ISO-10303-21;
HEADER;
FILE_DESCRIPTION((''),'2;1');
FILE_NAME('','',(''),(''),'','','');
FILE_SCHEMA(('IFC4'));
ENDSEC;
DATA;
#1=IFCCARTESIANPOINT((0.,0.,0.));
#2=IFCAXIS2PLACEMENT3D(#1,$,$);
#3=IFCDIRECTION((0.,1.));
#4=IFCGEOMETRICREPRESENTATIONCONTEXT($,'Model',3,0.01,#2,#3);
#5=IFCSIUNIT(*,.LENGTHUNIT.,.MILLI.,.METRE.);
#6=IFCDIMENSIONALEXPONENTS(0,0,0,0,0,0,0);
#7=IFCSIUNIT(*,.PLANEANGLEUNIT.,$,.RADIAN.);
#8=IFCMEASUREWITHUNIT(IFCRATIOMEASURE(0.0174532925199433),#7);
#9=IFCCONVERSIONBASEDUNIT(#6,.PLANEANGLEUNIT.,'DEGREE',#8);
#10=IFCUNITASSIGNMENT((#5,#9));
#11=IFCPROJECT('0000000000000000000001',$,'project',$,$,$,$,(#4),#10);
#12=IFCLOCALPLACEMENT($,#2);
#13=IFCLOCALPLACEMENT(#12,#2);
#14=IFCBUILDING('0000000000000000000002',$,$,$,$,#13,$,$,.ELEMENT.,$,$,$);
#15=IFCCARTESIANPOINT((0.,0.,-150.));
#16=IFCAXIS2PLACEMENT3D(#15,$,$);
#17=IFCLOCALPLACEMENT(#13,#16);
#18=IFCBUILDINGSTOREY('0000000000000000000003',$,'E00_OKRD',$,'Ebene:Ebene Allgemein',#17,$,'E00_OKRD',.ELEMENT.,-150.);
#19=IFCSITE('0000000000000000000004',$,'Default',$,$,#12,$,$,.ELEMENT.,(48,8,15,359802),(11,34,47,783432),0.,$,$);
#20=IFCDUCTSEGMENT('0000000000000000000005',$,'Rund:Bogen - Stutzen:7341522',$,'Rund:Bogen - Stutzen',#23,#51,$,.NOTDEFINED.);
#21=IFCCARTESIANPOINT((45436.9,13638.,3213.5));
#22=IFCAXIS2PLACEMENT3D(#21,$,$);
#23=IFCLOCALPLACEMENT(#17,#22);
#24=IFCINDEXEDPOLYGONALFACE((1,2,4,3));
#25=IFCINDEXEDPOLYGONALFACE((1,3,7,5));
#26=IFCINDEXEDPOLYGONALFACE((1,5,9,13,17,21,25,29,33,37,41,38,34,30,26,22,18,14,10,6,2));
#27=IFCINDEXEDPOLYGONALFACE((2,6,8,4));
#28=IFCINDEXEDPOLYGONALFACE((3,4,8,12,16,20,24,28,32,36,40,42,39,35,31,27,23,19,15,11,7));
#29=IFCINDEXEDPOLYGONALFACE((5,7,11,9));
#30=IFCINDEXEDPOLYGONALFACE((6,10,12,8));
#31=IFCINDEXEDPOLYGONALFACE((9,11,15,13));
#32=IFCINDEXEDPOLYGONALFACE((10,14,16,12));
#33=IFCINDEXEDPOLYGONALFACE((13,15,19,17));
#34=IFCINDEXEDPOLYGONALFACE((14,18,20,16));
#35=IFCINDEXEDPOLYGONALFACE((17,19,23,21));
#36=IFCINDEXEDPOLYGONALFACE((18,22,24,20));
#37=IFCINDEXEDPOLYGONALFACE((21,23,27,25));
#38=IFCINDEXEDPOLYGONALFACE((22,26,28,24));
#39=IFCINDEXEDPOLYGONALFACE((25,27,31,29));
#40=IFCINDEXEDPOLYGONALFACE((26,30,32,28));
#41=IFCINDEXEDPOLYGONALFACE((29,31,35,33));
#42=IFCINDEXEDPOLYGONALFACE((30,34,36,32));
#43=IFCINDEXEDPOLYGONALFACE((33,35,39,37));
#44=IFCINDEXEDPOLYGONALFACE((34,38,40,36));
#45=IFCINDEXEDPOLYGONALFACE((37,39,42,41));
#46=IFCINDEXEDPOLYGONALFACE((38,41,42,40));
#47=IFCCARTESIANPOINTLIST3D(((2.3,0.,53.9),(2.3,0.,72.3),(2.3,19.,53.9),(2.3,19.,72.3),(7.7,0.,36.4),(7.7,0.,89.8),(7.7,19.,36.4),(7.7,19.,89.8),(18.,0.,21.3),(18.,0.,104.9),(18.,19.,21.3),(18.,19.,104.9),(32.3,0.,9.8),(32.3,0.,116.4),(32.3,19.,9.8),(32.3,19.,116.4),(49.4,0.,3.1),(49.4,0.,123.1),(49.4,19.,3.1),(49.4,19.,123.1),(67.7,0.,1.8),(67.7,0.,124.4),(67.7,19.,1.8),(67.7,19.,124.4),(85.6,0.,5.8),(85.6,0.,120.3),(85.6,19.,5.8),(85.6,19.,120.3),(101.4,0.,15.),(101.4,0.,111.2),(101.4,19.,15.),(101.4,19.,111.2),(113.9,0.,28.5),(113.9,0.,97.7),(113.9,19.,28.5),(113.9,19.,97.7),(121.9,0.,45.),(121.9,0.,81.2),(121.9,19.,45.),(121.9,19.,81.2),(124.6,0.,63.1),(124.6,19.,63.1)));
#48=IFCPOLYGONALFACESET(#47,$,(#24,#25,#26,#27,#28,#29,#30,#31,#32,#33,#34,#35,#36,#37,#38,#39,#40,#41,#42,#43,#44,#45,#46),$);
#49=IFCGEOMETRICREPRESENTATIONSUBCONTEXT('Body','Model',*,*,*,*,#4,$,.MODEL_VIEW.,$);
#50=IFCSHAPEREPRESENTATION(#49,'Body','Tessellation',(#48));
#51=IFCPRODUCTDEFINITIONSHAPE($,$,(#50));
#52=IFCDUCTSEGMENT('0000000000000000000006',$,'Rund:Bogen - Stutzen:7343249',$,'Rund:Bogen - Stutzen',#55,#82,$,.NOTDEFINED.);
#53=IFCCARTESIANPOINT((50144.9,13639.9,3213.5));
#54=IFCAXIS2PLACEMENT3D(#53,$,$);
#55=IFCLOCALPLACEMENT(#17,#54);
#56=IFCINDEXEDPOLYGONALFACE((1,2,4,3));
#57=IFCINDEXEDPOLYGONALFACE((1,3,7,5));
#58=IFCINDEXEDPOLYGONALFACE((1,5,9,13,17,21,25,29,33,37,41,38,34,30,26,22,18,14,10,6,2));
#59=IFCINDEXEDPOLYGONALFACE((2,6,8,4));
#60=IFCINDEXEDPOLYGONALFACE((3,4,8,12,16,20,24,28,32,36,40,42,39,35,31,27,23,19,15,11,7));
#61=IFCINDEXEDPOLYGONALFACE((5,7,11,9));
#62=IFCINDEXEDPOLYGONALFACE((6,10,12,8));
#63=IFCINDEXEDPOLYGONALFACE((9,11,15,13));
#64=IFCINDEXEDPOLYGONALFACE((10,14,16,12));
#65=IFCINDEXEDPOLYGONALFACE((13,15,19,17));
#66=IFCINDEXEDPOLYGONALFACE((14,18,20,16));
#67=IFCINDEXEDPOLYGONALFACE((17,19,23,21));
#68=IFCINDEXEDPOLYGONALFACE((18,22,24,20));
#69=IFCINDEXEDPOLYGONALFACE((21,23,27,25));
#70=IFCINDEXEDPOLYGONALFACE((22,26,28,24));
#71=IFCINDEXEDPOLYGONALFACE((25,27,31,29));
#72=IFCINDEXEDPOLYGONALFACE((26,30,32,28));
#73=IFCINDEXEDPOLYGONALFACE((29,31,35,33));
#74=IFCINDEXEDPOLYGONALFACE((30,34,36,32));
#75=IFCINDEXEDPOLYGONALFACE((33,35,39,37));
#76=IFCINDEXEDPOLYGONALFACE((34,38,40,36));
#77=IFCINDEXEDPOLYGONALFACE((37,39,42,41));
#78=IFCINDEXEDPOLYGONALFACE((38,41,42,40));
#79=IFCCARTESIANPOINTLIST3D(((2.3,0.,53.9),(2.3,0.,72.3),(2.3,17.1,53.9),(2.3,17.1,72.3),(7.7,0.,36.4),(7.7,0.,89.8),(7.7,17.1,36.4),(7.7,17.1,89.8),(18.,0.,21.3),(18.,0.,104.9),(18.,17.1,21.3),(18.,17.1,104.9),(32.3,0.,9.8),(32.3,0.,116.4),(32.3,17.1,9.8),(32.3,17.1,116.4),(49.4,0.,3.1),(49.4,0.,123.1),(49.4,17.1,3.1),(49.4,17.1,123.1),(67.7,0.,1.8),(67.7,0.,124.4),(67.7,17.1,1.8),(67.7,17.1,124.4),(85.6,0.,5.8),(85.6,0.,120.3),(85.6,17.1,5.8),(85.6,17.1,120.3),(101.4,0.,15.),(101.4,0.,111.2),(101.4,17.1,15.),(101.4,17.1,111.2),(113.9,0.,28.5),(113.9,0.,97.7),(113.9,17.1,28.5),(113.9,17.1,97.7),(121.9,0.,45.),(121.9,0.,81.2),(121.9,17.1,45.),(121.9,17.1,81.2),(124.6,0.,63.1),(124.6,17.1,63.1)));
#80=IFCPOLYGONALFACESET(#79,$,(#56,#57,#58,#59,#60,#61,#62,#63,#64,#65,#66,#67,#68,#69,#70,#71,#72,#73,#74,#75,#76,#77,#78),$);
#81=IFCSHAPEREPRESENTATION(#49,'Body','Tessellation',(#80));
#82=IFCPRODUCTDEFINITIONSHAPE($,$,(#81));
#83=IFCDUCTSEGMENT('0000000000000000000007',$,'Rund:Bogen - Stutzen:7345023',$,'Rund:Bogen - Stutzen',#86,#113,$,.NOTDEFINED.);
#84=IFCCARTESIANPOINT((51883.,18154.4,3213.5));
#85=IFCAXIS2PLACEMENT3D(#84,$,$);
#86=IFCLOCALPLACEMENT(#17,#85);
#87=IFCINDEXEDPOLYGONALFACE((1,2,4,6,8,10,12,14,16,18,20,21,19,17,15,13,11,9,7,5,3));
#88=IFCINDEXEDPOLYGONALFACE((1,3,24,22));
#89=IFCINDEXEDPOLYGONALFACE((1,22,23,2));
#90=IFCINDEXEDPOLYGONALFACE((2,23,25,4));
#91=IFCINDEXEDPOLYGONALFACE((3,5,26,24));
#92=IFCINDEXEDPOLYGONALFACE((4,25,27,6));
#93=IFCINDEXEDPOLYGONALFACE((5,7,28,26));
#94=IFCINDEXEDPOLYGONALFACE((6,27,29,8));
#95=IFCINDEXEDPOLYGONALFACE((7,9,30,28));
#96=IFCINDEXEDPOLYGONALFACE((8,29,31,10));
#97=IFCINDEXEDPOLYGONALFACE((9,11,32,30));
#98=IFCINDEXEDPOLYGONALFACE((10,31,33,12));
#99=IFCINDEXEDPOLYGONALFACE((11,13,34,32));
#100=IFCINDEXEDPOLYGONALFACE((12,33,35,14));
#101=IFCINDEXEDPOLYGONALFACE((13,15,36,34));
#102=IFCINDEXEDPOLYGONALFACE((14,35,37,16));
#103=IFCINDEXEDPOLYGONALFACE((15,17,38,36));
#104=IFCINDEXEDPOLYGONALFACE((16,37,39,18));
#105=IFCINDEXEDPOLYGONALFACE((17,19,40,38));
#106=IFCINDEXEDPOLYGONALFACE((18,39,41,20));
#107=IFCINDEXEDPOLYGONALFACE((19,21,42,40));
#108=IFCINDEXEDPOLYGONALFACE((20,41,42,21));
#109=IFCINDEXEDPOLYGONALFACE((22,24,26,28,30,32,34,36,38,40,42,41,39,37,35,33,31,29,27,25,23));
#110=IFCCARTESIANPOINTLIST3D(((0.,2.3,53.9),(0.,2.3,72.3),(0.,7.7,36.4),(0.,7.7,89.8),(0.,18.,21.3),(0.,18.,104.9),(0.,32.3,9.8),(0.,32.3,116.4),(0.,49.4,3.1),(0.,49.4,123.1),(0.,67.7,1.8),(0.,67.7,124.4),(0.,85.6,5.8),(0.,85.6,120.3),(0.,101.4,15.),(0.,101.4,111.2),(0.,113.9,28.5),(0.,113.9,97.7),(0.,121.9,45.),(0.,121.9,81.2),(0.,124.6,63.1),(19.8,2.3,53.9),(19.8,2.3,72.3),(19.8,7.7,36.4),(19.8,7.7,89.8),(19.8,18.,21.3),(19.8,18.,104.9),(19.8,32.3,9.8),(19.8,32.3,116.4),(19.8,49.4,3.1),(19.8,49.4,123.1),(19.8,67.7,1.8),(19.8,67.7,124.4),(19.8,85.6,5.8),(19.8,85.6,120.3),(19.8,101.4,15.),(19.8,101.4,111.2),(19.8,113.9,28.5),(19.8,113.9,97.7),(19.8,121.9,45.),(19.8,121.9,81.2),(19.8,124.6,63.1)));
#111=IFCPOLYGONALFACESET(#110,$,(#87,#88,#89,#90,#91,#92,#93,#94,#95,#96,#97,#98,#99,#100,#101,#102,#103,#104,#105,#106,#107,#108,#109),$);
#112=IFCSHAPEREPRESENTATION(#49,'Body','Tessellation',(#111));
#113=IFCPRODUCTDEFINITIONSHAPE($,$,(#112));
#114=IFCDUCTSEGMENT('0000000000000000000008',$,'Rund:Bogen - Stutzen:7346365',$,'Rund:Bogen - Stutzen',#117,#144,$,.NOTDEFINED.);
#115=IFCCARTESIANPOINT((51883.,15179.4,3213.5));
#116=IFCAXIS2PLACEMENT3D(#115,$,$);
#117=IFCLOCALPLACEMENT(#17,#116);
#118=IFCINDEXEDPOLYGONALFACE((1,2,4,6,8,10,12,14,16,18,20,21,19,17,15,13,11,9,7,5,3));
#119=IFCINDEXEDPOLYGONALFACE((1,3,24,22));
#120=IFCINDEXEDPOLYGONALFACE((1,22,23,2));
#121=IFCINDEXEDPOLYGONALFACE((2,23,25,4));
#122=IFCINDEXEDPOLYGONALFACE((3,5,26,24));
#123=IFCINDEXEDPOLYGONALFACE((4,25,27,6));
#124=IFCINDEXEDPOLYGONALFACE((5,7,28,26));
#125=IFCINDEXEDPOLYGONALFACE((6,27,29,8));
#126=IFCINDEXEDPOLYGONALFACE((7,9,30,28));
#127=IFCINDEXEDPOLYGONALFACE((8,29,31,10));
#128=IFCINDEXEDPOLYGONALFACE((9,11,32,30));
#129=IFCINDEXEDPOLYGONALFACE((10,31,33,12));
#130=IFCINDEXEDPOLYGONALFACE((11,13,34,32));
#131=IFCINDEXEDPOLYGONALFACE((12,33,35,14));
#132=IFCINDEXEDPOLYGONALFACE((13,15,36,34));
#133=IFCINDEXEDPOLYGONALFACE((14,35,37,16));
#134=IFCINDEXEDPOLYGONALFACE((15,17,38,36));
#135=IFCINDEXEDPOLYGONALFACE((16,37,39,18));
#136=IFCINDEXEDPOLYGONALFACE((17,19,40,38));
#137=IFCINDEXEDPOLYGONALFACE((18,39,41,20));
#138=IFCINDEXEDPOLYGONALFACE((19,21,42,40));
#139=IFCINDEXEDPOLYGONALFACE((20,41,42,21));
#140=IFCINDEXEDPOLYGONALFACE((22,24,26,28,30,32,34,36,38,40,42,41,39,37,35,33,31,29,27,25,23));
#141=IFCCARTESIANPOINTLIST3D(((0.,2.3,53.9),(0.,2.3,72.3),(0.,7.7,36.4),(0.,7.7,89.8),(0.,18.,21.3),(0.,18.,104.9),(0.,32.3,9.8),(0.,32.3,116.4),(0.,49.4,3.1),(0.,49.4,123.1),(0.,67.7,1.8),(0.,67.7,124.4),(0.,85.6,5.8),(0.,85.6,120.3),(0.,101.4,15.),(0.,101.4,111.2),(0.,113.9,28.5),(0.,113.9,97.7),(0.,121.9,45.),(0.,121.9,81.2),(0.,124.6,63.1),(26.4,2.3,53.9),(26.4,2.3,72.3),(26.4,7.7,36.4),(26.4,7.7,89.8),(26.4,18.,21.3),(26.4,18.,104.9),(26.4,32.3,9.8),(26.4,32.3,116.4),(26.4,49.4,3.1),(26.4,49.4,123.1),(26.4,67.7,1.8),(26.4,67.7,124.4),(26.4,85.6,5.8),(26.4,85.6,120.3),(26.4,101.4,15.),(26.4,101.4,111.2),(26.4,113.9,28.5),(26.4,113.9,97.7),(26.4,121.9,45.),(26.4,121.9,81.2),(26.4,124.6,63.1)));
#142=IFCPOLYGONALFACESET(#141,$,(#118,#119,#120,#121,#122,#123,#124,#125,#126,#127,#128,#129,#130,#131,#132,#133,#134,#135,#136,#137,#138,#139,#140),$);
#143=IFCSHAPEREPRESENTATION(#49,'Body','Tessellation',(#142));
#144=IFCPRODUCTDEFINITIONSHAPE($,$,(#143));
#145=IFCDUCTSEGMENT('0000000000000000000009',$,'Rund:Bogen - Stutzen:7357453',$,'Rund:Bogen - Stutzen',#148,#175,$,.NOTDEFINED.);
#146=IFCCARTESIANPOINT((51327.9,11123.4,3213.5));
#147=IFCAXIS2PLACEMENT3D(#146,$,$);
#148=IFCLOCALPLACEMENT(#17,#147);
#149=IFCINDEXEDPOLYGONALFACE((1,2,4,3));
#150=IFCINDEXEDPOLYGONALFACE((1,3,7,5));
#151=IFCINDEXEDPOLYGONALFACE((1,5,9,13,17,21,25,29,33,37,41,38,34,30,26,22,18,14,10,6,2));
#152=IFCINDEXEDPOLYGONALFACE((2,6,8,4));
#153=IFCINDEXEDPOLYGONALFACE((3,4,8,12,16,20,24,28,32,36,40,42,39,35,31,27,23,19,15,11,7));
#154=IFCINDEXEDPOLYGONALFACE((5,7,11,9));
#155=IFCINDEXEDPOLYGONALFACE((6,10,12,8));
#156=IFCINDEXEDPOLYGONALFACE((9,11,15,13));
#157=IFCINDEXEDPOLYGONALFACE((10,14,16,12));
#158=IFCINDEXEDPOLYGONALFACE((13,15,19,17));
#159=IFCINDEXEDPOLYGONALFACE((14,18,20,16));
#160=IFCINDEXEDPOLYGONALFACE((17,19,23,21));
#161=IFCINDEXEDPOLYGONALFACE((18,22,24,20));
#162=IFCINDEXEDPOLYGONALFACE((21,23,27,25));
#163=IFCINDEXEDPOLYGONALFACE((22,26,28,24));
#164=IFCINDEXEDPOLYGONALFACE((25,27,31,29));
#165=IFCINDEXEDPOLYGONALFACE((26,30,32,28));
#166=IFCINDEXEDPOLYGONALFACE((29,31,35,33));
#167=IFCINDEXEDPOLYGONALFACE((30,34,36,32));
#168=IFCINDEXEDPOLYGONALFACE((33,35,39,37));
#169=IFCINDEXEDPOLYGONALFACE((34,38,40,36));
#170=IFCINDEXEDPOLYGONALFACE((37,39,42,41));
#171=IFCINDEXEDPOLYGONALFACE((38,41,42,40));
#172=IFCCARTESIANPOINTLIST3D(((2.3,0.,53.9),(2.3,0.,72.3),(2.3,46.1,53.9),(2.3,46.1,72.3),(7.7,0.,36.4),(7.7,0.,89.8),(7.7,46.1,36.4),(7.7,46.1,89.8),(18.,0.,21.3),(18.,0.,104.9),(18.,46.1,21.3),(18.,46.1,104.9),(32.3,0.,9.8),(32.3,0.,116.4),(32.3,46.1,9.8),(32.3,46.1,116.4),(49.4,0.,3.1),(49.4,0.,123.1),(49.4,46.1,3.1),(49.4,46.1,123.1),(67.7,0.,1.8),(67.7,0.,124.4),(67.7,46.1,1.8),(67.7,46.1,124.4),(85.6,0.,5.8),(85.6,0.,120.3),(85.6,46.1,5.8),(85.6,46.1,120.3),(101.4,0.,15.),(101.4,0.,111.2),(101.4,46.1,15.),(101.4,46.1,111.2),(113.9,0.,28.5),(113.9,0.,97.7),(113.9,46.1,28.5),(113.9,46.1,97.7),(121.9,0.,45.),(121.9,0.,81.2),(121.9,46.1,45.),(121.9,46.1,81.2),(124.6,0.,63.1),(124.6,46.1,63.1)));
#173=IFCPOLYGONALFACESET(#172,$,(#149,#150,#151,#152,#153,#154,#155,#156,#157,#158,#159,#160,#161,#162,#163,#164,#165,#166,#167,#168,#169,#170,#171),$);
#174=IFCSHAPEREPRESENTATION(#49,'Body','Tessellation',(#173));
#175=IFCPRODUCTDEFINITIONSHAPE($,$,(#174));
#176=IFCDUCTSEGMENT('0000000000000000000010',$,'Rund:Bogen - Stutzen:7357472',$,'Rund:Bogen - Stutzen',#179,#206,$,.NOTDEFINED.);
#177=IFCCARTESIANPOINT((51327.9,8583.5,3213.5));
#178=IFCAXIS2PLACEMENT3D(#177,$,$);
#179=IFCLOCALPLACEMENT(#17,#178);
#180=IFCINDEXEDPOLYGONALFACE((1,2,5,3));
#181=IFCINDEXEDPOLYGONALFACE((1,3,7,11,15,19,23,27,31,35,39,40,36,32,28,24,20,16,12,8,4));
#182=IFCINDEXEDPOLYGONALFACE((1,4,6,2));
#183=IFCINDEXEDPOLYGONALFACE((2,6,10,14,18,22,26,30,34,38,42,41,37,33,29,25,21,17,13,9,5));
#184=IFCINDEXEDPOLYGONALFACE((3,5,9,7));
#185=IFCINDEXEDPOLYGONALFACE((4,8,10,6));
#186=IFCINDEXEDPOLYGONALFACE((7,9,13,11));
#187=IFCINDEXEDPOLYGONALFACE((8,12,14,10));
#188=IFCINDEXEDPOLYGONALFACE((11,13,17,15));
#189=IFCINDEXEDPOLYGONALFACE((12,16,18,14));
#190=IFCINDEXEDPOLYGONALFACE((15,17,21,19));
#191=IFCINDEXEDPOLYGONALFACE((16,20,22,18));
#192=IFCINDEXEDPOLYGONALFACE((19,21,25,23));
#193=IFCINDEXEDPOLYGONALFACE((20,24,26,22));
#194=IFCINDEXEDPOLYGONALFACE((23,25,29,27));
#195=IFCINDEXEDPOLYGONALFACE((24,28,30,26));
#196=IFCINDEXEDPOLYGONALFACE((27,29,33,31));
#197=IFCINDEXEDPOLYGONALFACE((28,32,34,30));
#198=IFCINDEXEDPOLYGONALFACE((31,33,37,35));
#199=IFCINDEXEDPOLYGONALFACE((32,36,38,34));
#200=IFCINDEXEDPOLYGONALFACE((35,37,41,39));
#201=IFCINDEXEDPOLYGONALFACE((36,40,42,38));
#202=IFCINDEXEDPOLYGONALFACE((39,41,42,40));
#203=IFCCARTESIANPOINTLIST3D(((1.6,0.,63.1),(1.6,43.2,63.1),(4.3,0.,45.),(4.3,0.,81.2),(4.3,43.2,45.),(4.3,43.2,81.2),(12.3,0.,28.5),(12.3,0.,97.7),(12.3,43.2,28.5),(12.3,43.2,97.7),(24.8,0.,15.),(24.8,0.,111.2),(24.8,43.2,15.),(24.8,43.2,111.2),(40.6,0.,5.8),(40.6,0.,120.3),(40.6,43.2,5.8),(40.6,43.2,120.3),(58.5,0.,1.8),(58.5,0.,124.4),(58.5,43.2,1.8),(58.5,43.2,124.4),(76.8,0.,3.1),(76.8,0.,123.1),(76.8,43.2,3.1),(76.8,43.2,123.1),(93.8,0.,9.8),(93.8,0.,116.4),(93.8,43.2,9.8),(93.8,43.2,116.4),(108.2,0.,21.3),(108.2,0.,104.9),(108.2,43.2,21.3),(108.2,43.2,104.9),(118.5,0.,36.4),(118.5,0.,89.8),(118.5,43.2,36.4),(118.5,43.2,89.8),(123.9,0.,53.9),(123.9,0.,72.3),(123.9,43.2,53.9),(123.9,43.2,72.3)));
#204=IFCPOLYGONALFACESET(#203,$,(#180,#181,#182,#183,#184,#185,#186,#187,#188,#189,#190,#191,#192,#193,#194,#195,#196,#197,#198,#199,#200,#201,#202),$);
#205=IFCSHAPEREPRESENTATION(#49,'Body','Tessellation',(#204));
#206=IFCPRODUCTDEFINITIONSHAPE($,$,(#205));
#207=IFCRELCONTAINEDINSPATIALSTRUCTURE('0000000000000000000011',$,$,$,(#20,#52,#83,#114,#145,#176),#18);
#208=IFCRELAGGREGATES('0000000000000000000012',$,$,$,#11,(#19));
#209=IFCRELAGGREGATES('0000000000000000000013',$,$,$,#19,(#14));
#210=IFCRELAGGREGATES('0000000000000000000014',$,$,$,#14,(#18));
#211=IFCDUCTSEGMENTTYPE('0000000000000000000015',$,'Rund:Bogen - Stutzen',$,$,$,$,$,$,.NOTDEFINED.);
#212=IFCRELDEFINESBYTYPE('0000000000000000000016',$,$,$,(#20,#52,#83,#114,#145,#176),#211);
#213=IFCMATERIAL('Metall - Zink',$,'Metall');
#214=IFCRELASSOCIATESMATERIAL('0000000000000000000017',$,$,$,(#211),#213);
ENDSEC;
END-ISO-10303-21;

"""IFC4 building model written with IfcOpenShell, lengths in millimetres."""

from ifc_helpers import new_model, entity, si_unit, converted_unit, direction, frame, frame_2d, origin, origin_2d_with_axis, place, context, subcontext, project, spatial, circle, extrude, material, type_object, element, save


model = new_model("IFC4")

# Units and contexts
model_context = context("Model", 3, precision=0.01, world=origin(), true_north=direction((0.0, 1.0)))
body_context = subcontext(model_context, "Body", "Model", "MODEL_VIEW")
ifc_project = project(units=[si_unit("LENGTHUNIT", "METRE", prefix="MILLI"), converted_unit("PLANEANGLEUNIT", "DEGREE", entity("IfcRatioMeasure", 0.0174532925199433), si_unit("PLANEANGLEUNIT", "RADIAN"), dimensions=[0, 0, 0, 0, 0, 0, 0])], contexts=[model_context])

# Site, building, storey
site_placement = place(None, origin())
site = spatial("IfcSite", under=ifc_project, at=site_placement, Name="Default", CompositionType="ELEMENT", RefLatitude=(48, 8, 15, 359802), RefLongitude=(11, 34, 47, 783432), RefElevation=0.0)
building_placement = place(site_placement, origin())
building = spatial("IfcBuilding", under=site, at=building_placement, CompositionType="ELEMENT")
storey_placement = place(building_placement, frame((0.0, 0.0, -150.0)))
storey = spatial("IfcBuildingStorey", under=building, at=storey_placement, Name="E00_OKRD", ObjectType="Ebene:Ebene Allgemein", LongName="E00_OKRD", CompositionType="ELEMENT", Elevation=-150.0)

# Shared definitions
ifc_material_1 = material(Name="Metall - Zink", Category="Metall")

# Duct segments
duct_segment_type_1 = type_object("IfcDuctSegmentType", Name="Rund:Bogen - Stutzen", PredefinedType="NOTDEFINED", material=ifc_material_1)
duct_segment_1_placement = place(storey_placement, frame((45436.9, 13638.0, 3213.5)))
element("IfcDuctSegment", 1, at=duct_segment_1_placement, inside=storey, type_object=duct_segment_type_1, Name="Rund:Bogen - Stutzen:7341522", ObjectType="Rund:Bogen - Stutzen", PredefinedType="NOTDEFINED", context=body_context, shape_type="SweptSolid", body=[
    extrude(circle(Radius=61.5, at=frame_2d((0.0, 0.0), x_axis=(1.0, 0.0))), frame((63.1, 0.0, 63.1), z_axis=(0.0, 1.0, 0.0), x_axis=(1.0, 0.0, 0.0)), (0.0, 0.0, 1.0), 19.0),
])
duct_segment_2_placement = place(storey_placement, frame((50144.9, 13639.9, 3213.5)))
element("IfcDuctSegment", 2, at=duct_segment_2_placement, inside=storey, type_object=duct_segment_type_1, Name="Rund:Bogen - Stutzen:7343249", ObjectType="Rund:Bogen - Stutzen", PredefinedType="NOTDEFINED", context=body_context, shape_type="SweptSolid", body=[
    extrude(circle(Radius=61.5, at=frame_2d((0.0, 0.0), x_axis=(1.0, 0.0))), frame((63.1, 0.0, 63.1), z_axis=(0.0, 1.0, 0.0), x_axis=(1.0, 0.0, 0.0)), (0.0, 0.0, 1.0), 17.1),
])
duct_segment_3_placement = place(storey_placement, frame((51883.0, 18154.4, 3213.5)))
element("IfcDuctSegment", 3, at=duct_segment_3_placement, inside=storey, type_object=duct_segment_type_1, Name="Rund:Bogen - Stutzen:7345023", ObjectType="Rund:Bogen - Stutzen", PredefinedType="NOTDEFINED", context=body_context, shape_type="SweptSolid", body=[
    extrude(circle(Radius=61.5, at=origin_2d_with_axis()), frame((0.0, 63.1, 63.1), z_axis=(1.0, 0.0, 0.0), x_axis=(0.0, 1.0, 0.0)), (0.0, 0.0, 1.0), 19.8),
])
duct_segment_4_placement = place(storey_placement, frame((51883.0, 15179.4, 3213.5)))
element("IfcDuctSegment", 4, at=duct_segment_4_placement, inside=storey, type_object=duct_segment_type_1, Name="Rund:Bogen - Stutzen:7346365", ObjectType="Rund:Bogen - Stutzen", PredefinedType="NOTDEFINED", context=body_context, shape_type="SweptSolid", body=[
    extrude(circle(Radius=61.5, at=origin_2d_with_axis()), frame((0.0, 63.1, 63.1), z_axis=(1.0, 0.0, 0.0), x_axis=(0.0, 1.0, 0.0)), (0.0, 0.0, 1.0), 26.4),
])
duct_segment_5_placement = place(storey_placement, frame((51327.9, 11123.4, 3213.5)))
element("IfcDuctSegment", 5, at=duct_segment_5_placement, inside=storey, type_object=duct_segment_type_1, Name="Rund:Bogen - Stutzen:7357453", ObjectType="Rund:Bogen - Stutzen", PredefinedType="NOTDEFINED", context=body_context, shape_type="SweptSolid", body=[
    extrude(circle(Radius=61.5, at=origin_2d_with_axis()), frame((63.1, 0.0, 63.1), z_axis=(0.0, 1.0, 0.0), x_axis=(1.0, 0.0, 0.0)), (0.0, 0.0, 1.0), 46.1),
])
duct_segment_6_placement = place(storey_placement, frame((51327.9, 8583.5, 3213.5)))
element("IfcDuctSegment", 6, at=duct_segment_6_placement, inside=storey, type_object=duct_segment_type_1, Name="Rund:Bogen - Stutzen:7357472", ObjectType="Rund:Bogen - Stutzen", PredefinedType="NOTDEFINED", context=body_context, shape_type="SweptSolid", body=[
    extrude(circle(Radius=61.5, at=frame_2d((0.0, 0.0), x_axis=(1.0, 0.0))), frame((63.1, 0.0, 63.1), z_axis=(0.0, 1.0, 0.0), x_axis=(-1.0, 0.0, 0.0)), (0.0, 0.0, 1.0), 43.2),
])

save(model, "model.ifc")
